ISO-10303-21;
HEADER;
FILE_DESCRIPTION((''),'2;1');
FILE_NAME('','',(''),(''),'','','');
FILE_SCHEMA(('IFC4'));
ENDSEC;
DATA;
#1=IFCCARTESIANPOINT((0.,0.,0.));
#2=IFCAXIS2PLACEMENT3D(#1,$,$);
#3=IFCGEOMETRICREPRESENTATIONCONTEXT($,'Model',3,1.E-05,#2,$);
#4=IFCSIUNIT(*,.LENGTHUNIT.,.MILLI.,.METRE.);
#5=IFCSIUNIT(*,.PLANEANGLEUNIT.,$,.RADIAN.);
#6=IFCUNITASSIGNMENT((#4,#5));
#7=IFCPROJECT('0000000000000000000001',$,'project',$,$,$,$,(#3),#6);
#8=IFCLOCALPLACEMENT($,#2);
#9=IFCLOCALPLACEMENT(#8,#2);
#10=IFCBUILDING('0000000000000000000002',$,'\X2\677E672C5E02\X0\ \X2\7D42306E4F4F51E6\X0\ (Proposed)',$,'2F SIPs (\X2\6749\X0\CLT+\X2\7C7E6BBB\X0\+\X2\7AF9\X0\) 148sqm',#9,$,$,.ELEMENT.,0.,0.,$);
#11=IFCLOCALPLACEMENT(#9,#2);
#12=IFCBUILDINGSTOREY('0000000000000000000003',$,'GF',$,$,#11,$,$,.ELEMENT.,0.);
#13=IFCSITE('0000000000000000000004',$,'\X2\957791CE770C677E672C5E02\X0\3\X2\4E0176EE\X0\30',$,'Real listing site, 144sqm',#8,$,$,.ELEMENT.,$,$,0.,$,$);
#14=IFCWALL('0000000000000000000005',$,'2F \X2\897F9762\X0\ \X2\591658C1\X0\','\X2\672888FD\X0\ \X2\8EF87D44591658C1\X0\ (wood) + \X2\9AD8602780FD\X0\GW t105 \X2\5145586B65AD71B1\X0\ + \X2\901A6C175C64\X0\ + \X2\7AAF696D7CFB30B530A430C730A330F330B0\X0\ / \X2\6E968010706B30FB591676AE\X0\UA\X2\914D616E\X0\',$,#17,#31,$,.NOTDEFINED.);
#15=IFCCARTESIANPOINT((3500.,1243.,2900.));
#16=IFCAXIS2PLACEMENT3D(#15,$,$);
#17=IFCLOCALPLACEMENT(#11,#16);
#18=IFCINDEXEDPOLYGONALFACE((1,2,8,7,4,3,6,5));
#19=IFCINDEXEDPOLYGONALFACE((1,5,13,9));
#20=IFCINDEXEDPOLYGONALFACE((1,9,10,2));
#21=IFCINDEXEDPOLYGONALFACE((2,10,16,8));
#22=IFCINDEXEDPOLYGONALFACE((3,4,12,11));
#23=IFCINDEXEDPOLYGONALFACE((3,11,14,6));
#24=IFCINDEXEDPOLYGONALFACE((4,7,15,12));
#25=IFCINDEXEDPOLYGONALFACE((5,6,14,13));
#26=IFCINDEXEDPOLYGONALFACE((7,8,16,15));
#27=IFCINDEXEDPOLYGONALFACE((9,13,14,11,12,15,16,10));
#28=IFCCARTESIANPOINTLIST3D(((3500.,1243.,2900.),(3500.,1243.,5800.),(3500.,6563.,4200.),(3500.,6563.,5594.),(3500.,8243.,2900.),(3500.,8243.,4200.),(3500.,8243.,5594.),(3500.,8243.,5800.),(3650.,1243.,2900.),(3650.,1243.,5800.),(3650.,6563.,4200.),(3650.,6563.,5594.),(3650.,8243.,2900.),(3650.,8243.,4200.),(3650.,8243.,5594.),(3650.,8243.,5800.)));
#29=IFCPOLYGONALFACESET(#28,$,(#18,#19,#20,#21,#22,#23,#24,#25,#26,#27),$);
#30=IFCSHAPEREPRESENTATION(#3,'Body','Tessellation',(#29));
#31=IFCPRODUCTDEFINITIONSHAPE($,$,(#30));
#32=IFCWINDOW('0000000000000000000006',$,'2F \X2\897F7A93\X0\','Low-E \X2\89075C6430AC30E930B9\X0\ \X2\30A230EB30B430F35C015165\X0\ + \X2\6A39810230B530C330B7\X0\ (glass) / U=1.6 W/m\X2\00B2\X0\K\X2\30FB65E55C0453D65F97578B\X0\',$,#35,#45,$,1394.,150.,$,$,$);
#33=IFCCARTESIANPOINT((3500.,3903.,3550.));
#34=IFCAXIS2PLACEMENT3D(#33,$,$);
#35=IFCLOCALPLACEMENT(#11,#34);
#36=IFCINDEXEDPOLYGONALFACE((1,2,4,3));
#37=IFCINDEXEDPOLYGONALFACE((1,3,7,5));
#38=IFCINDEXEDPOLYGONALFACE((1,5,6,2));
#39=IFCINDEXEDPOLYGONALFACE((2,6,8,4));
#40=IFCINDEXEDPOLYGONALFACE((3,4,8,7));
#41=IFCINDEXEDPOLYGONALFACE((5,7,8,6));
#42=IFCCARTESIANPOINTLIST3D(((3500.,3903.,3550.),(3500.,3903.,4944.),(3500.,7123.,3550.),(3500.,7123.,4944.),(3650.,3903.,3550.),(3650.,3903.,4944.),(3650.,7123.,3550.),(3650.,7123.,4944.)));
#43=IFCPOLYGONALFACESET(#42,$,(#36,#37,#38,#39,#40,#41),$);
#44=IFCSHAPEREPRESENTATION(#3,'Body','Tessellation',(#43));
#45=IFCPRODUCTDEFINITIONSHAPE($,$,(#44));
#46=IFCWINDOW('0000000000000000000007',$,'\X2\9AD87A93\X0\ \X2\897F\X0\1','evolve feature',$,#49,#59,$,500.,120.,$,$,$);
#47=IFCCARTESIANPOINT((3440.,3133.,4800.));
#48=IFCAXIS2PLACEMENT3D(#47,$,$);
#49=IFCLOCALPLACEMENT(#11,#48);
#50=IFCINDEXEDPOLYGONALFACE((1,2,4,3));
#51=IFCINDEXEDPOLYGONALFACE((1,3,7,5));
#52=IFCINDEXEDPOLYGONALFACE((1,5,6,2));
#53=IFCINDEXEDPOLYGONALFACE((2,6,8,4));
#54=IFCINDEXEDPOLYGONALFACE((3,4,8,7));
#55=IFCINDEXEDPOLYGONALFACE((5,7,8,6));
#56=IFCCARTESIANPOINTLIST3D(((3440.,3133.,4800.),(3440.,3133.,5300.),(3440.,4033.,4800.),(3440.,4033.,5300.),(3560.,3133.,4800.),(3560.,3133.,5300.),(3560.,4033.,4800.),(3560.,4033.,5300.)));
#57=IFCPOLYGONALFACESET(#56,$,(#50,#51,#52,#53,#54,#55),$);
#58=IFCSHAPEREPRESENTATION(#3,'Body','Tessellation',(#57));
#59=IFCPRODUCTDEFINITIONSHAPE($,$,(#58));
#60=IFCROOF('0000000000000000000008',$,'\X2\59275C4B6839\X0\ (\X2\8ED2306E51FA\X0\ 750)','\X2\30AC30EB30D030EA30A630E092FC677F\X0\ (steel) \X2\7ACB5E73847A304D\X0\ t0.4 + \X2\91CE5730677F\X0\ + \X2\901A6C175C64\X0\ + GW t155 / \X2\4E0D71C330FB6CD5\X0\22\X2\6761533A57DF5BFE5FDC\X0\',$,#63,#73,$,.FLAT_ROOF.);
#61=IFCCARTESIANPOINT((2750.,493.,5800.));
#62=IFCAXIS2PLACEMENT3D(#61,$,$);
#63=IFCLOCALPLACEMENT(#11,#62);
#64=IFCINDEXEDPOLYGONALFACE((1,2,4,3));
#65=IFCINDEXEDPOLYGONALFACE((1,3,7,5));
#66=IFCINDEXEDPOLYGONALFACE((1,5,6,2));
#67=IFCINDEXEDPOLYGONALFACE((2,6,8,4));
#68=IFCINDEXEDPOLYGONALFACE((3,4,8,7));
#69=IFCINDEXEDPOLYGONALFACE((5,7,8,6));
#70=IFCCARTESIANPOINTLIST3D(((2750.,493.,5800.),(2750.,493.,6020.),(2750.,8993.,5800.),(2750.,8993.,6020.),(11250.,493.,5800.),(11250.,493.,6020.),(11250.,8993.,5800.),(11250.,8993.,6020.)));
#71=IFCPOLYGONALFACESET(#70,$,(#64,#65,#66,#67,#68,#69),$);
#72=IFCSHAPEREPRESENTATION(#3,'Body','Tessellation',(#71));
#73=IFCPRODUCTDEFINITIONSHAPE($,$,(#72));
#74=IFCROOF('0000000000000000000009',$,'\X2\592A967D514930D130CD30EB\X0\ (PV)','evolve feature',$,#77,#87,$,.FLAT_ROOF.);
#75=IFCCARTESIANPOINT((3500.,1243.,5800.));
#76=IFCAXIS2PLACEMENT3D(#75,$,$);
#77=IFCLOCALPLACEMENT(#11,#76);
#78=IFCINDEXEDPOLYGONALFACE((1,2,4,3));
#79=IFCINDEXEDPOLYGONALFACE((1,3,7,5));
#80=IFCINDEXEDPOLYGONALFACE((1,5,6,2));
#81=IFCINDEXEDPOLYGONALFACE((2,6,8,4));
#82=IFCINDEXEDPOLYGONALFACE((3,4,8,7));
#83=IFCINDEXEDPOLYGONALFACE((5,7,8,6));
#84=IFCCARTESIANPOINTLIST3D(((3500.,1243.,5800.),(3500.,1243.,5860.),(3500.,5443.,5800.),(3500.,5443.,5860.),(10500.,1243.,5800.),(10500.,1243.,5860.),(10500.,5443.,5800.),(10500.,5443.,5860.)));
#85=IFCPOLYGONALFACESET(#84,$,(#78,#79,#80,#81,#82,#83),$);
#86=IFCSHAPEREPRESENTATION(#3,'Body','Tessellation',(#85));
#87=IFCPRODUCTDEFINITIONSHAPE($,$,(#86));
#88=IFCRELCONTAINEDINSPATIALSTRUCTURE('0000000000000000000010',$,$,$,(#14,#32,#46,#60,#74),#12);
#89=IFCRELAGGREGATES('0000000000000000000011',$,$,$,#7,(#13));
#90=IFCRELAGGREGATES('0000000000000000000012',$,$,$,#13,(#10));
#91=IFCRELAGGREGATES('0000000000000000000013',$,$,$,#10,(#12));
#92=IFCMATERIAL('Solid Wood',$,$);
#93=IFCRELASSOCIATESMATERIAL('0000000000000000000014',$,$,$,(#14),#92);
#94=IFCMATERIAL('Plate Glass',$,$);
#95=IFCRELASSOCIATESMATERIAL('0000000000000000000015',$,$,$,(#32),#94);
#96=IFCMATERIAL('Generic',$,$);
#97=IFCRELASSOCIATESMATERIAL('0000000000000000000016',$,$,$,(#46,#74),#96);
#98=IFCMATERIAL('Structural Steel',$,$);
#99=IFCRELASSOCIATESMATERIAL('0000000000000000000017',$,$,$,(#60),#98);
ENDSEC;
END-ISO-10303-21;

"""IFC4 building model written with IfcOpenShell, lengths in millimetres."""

from ifc_helpers import new_model, si_unit, frame, frame_2d, origin, place, context, project, spatial, rectangle, extrude, material, element, fill, save


model = new_model("IFC4")

# Units and contexts
model_context = context("Model", 3, precision=1e-05, world=origin())
ifc_project = project(units=[si_unit("LENGTHUNIT", "METRE", prefix="MILLI"), si_unit("PLANEANGLEUNIT", "RADIAN")], contexts=[model_context])

# Site, building, storey
site_placement = place(None, origin())
site = spatial("IfcSite", under=ifc_project, at=site_placement, Name="長野県松本市3丁目30", ObjectType="Real listing site, 144sqm", CompositionType="ELEMENT", RefElevation=0.0)
building_placement = place(site_placement, origin())
building = spatial("IfcBuilding", under=site, at=building_placement, Name="松本市 終の住処 (Proposed)", ObjectType="2F SIPs (杉CLT+籾殻+竹) 148sqm", CompositionType="ELEMENT", ElevationOfRefHeight=0.0, ElevationOfTerrain=0.0)
storey_placement = place(building_placement, origin())
storey = spatial("IfcBuildingStorey", under=building, at=storey_placement, Name="GF", CompositionType="ELEMENT", Elevation=0.0)

# Shared definitions
ifc_material_1 = material(Name="Solid Wood")
ifc_material_2 = material(Name="Generic")

# Shared definitions
ifc_material_3 = material(Name="Plate Glass")

# Wall, openings, windows
wall_1_placement = place(storey_placement, frame((3500.0, 1243.0, 2900.0)))
wall_1 = element("IfcWall", 1, at=wall_1_placement, inside=storey, material=ifc_material_1, Name="2F 西面 外壁", Description="木製 軸組外壁 (wood) + 高性能GW t105 充填断熱 + 通気層 + 窯業系サイディング / 準耐火・外皮UA配慮", PredefinedType="NOTDEFINED", context=model_context, shape_type="SweptSolid", body=[
    extrude(rectangle(XDim=150.0, YDim=7000.0, at=frame_2d((75.0, 3500.0))), frame((3500.0, 1243.0, 2900.0)), (0.0, 0.0, 1.0), 2900.0),
])
opening_1_placement = place(storey_placement, frame((3500.0, 3903.0, 3550.0)))
opening_1 = element("IfcOpeningElement", 2, at=opening_1_placement, cuts=wall_1, PredefinedType="NOTDEFINED", context=model_context, shape_type="SweptSolid", body=[
    extrude(rectangle(XDim=150.0, YDim=3220.0, at=frame_2d((75.0, 1610.0))), frame((3500.0, 3903.0, 3550.0)), (0.0, 0.0, 1.0), 1394.0),
])
opening_2_placement = place(storey_placement, frame((3440.0, 3133.0, 4800.0)))
opening_2 = element("IfcOpeningElement", 3, at=opening_2_placement, cuts=wall_1, PredefinedType="NOTDEFINED", context=model_context, shape_type="SweptSolid", body=[
    extrude(rectangle(XDim=120.0, YDim=900.0, at=frame_2d((60.0, 450.0))), frame((3440.0, 3133.0, 4800.0)), (0.0, 0.0, 1.0), 500.0),
])
window_1_placement = place(storey_placement, frame((3500.0, 3903.0, 3550.0)))
window_1 = element("IfcWindow", 4, at=window_1_placement, inside=storey, material=ifc_material_3, Name="2F 西窓", Description="Low-E 複層ガラス アルゴン封入 + 樹脂サッシ (glass) / U=1.6 W/m²K・日射取得型", OverallHeight=1394.0, OverallWidth=150.0, context=model_context, shape_type="SweptSolid", body=[
    extrude(rectangle(XDim=150.0, YDim=3220.0, at=frame_2d((75.0, 1610.0))), frame((3500.0, 3903.0, 3550.0)), (0.0, 0.0, 1.0), 1394.0),
])
fill(opening_1, window_1)
window_2_placement = place(storey_placement, frame((3440.0, 3133.0, 4800.0)))
window_2 = element("IfcWindow", 5, at=window_2_placement, inside=storey, material=ifc_material_2, Name="高窓 西1", Description="evolve feature", OverallHeight=500.0, OverallWidth=120.0, context=model_context, shape_type="SweptSolid", body=[
    extrude(rectangle(XDim=120.0, YDim=900.0, at=frame_2d((60.0, 450.0))), frame((3440.0, 3133.0, 4800.0)), (0.0, 0.0, 1.0), 500.0),
])
fill(opening_2, window_2)

# Roofs
ifc_material_4 = material(Name="Structural Steel")
roof_1_placement = place(storey_placement, frame((2750.0, 493.0, 5800.0)))
element("IfcRoof", 6, at=roof_1_placement, inside=storey, material=ifc_material_4, Name="大屋根 (軒の出 750)", Description="ガルバリウム鋼板 (steel) 立平葺き t0.4 + 野地板 + 通気層 + GW t155 / 不燃・法22条区域対応", PredefinedType="FLAT_ROOF", context=model_context, shape_type="SweptSolid", body=[
    extrude(rectangle(XDim=8500.0, YDim=8500.0, at=frame_2d((4250.0, 4250.0))), frame((2750.0, 493.0, 5800.0)), (0.0, 0.0, 1.0), 220.0),
])
roof_2_placement = place(storey_placement, frame((3500.0, 1243.0, 5800.0)))
element("IfcRoof", 7, at=roof_2_placement, inside=storey, material=ifc_material_2, Name="太陽光パネル (PV)", Description="evolve feature", PredefinedType="FLAT_ROOF", context=model_context, shape_type="SweptSolid", body=[
    extrude(rectangle(XDim=7000.0, YDim=4200.0, at=frame_2d((3500.0, 2100.0))), frame((3500.0, 1243.0, 5800.0)), (0.0, 0.0, 1.0), 60.0),
])

save(model, "model.ifc")
